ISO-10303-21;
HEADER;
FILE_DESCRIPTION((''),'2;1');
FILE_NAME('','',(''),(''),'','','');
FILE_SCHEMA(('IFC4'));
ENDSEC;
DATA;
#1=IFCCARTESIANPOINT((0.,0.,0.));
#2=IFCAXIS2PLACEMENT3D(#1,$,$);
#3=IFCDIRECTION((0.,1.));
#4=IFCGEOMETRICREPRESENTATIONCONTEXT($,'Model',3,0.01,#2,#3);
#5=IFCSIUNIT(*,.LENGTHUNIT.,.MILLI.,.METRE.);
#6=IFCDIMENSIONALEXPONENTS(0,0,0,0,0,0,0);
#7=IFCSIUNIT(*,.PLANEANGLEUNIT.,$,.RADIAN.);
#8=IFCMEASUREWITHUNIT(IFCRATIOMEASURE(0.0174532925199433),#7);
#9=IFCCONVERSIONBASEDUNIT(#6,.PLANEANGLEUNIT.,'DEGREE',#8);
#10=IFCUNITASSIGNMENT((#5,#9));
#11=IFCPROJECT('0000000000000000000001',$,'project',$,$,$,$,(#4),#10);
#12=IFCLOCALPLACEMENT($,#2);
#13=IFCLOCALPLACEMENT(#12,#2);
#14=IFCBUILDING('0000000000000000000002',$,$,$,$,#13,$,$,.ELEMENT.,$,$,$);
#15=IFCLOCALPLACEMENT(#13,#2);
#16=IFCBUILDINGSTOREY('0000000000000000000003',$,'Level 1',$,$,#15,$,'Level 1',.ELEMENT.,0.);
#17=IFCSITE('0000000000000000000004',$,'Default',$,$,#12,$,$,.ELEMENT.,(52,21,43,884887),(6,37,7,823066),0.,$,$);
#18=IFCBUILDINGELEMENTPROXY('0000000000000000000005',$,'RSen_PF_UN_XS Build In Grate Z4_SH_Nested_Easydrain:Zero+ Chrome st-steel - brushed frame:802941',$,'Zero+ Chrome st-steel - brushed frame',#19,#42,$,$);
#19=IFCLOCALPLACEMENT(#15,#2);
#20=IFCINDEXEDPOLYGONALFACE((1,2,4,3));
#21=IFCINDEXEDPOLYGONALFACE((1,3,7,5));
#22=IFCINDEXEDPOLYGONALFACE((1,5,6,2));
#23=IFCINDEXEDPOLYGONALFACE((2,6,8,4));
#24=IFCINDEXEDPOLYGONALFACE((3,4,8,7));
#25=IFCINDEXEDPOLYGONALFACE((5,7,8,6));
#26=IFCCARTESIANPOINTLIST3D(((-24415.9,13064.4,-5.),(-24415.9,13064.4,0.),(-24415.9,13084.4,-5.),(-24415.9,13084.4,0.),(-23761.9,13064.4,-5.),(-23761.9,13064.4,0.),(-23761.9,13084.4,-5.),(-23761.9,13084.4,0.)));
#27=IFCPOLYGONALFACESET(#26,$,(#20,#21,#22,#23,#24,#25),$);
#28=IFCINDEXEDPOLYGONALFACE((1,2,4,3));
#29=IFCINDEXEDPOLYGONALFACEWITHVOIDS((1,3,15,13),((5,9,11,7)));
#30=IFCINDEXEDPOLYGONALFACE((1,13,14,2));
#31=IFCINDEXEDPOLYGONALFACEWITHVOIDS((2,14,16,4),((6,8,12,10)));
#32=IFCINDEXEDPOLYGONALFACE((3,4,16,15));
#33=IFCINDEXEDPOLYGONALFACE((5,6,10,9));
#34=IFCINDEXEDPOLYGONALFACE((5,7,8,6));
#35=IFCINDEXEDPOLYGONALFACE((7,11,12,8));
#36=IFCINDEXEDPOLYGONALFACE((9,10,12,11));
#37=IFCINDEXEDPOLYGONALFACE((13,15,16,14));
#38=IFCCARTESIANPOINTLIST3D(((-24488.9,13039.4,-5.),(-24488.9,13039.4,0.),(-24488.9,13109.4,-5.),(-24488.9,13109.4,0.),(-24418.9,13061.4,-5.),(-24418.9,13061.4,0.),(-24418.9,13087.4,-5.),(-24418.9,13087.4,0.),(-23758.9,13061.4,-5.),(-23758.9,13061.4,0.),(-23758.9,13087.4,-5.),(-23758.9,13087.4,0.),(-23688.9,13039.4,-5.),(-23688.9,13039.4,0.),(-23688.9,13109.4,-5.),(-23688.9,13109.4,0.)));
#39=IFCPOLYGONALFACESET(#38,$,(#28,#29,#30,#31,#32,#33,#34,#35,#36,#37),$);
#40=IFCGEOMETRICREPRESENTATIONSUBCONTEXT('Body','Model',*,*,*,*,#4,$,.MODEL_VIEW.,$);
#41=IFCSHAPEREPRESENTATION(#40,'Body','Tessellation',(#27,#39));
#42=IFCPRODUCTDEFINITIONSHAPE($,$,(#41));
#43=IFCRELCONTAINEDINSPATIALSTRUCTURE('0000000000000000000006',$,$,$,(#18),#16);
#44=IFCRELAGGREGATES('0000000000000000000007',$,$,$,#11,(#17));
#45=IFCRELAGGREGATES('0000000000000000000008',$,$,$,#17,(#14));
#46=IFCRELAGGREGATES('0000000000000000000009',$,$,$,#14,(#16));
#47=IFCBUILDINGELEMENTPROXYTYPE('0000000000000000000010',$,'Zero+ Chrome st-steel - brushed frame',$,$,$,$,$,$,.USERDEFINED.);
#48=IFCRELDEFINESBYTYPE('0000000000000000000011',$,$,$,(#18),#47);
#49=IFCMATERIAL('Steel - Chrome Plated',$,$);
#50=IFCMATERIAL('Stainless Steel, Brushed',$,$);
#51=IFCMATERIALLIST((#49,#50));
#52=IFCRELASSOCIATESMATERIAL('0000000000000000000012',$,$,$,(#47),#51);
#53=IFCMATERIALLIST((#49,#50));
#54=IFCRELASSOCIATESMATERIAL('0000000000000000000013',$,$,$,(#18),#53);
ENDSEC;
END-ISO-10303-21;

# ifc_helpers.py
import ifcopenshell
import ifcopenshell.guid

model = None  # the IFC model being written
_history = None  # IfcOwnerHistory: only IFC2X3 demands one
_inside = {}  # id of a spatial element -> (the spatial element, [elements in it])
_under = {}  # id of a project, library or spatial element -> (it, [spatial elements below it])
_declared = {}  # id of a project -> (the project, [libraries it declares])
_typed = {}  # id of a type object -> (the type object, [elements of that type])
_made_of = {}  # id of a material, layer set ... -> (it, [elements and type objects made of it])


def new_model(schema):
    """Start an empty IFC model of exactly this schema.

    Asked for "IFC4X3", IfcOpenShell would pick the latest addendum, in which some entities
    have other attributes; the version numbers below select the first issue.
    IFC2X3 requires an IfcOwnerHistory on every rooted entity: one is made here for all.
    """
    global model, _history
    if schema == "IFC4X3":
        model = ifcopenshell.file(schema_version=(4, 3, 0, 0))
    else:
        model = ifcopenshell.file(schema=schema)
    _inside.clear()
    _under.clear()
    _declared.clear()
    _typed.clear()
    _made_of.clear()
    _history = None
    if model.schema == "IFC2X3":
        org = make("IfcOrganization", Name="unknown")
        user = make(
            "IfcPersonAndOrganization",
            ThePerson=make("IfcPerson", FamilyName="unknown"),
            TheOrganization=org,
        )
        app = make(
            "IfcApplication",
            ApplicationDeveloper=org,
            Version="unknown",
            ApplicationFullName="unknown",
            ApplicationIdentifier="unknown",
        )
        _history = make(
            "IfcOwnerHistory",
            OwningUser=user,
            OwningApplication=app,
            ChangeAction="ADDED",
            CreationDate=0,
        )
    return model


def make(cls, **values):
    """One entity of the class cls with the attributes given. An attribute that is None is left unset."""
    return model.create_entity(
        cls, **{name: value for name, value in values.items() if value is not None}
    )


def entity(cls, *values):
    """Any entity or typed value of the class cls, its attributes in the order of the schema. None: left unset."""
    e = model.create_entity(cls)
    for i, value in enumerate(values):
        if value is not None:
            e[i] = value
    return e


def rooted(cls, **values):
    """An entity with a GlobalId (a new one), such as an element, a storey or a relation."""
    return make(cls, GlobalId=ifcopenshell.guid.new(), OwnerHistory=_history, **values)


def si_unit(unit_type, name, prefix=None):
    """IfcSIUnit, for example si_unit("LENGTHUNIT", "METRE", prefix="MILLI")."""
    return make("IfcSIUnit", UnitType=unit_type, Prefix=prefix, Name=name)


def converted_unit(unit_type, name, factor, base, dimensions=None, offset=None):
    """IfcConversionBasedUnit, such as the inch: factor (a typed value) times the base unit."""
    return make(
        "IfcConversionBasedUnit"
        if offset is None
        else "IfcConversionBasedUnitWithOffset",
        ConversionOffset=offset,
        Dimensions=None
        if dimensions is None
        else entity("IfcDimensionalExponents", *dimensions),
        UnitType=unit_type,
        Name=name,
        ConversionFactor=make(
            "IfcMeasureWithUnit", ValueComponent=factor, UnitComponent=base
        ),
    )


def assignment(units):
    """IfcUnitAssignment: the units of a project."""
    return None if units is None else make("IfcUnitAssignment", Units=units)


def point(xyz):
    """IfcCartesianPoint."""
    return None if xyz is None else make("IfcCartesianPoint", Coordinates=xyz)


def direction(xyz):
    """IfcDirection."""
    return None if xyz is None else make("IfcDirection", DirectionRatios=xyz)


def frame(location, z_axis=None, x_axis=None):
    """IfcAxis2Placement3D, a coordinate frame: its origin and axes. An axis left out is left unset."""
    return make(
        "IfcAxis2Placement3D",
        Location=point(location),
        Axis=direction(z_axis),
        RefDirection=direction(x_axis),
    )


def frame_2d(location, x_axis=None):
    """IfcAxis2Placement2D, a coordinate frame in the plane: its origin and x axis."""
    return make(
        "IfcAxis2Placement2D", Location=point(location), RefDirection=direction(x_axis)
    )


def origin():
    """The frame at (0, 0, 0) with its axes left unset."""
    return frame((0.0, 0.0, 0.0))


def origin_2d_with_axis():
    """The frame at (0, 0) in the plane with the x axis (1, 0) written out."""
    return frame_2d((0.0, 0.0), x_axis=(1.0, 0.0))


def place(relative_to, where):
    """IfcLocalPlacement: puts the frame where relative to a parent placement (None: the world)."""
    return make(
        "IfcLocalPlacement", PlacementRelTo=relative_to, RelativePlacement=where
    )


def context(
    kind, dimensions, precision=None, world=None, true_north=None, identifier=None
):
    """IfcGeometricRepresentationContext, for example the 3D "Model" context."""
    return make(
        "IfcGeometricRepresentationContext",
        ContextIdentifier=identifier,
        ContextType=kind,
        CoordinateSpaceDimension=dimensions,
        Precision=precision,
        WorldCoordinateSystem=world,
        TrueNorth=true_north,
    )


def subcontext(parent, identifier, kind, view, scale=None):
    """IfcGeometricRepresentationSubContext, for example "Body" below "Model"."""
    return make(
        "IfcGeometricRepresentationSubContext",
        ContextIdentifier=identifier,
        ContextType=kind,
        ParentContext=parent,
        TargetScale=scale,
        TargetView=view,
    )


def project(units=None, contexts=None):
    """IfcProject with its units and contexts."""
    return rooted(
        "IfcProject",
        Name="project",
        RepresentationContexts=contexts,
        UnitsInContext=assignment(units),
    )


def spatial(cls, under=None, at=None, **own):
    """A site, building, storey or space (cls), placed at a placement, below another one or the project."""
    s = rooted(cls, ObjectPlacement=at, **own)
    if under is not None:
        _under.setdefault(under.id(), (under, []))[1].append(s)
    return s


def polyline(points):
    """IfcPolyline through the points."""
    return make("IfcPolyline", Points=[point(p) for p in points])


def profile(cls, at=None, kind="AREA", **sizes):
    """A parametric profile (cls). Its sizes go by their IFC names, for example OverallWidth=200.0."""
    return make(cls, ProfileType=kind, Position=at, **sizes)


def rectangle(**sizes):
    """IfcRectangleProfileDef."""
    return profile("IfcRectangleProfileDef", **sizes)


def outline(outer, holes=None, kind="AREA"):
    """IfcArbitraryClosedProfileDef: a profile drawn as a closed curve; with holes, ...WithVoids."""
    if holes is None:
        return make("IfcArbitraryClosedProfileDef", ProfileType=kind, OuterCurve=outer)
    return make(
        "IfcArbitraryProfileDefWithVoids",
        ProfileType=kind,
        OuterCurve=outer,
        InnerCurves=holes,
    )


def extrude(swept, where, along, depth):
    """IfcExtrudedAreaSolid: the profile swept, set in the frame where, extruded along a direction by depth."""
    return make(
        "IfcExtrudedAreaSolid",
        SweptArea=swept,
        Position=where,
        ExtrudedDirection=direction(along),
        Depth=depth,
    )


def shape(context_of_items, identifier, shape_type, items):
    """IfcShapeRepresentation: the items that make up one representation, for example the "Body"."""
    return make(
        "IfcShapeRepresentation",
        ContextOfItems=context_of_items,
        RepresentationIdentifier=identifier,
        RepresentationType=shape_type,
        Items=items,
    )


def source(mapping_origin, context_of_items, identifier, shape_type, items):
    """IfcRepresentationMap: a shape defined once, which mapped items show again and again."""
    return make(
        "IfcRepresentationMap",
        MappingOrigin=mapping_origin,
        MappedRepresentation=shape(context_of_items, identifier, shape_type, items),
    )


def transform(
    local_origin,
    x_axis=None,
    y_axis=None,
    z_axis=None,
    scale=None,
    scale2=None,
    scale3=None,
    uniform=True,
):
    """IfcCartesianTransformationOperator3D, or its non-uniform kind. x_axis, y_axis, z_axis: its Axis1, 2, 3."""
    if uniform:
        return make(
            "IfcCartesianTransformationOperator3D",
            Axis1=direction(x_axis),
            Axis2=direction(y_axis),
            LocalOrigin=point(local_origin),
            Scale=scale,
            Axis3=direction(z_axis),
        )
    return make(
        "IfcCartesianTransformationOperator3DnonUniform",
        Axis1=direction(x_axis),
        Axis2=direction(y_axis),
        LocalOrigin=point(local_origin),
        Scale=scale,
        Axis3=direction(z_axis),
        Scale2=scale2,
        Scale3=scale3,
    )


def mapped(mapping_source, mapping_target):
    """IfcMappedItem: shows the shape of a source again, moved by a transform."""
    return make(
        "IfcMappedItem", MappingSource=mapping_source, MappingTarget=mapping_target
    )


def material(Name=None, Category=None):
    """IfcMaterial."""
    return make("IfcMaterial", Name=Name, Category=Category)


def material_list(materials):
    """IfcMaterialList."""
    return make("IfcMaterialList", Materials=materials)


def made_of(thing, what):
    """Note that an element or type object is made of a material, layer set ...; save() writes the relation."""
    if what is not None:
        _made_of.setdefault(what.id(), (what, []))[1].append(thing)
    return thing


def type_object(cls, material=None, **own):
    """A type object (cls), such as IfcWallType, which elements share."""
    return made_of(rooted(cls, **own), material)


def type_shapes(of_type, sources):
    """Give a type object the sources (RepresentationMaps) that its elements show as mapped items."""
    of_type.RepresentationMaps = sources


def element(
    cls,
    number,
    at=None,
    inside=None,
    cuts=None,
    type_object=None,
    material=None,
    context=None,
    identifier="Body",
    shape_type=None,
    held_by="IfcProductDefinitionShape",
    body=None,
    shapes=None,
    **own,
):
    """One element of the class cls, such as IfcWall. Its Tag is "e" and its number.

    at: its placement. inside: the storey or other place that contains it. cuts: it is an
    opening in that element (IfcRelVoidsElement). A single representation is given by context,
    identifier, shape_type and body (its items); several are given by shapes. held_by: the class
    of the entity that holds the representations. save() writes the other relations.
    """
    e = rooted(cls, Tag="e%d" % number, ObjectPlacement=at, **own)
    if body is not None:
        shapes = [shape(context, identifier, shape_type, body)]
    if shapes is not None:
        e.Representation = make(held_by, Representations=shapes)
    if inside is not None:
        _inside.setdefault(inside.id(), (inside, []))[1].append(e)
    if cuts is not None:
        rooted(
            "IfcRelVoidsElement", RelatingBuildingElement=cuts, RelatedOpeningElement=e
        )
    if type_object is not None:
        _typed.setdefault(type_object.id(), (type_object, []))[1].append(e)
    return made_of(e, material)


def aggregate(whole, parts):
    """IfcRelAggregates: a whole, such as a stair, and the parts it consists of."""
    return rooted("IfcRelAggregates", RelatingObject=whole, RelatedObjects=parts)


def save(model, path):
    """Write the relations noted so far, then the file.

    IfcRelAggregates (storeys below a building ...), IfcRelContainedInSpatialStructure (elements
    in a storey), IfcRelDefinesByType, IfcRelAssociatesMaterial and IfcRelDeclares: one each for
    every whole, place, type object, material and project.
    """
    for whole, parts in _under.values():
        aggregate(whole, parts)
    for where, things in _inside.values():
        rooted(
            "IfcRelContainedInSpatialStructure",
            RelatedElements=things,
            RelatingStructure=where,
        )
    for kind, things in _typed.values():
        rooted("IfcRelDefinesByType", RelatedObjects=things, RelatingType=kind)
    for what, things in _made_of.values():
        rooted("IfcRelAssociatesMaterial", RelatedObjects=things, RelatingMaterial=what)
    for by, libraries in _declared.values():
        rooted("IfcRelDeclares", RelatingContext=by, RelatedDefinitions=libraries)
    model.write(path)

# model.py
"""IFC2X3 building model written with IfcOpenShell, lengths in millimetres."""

from ifc_helpers import new_model, entity, si_unit, converted_unit, direction, frame, origin, origin_2d_with_axis, place, context, subcontext, project, spatial, polyline, rectangle, outline, extrude, source, transform, mapped, material, material_list, type_object, type_shapes, element, save


model = new_model("IFC2X3")

# Units and contexts
model_context = context("Model", 3, precision=0.01, world=origin(), true_north=direction((0.0, 1.0)))
body_context = subcontext(model_context, "Body", "Model", "MODEL_VIEW")
ifc_project = project(units=[si_unit("LENGTHUNIT", "METRE", prefix="MILLI"), converted_unit("PLANEANGLEUNIT", "DEGREE", entity("IfcRatioMeasure", 0.0174532925199433), si_unit("PLANEANGLEUNIT", "RADIAN"), dimensions=[0, 0, 0, 0, 0, 0, 0])], contexts=[model_context])

# Site, building, storey
site_placement = place(None, origin())
site = spatial("IfcSite", under=ifc_project, at=site_placement, Name="Default", CompositionType="ELEMENT", RefLatitude=(52, 21, 43, 884887), RefLongitude=(6, 37, 7, 823066), RefElevation=0.0)
building_placement = place(site_placement, origin())
building = spatial("IfcBuilding", under=site, at=building_placement, CompositionType="ELEMENT")
storey_placement = place(building_placement, origin())
storey = spatial("IfcBuildingStorey", under=building, at=storey_placement, Name="Level 1", LongName="Level 1", CompositionType="ELEMENT", Elevation=0.0)

# Shared definitions
ifc_material_1 = material(Name="Stainless Steel, Brushed")

# Building element proxy
ifc_material_2 = material(Name="Steel - Chrome Plated")
ifc_material_list_1 = material_list([ifc_material_2, ifc_material_1])
ifc_material_list_2 = material_list([ifc_material_2, ifc_material_1])
building_element_proxy_type_1 = type_object("IfcBuildingElementProxyType", Name="Zero+ Chrome st-steel - brushed frame", PredefinedType="USERDEFINED", material=ifc_material_list_2)
shared_shape_1 = source(origin(), body_context, "Body", "SweptSolid", [
    extrude(rectangle(XDim=654.0, YDim=20.0, at=origin_2d_with_axis()), frame((0.0, 0.0, 0.0), z_axis=(0.0, 0.0, 1.0), x_axis=(-1.0, 0.0, 0.0)), (0.0, 0.0, 1.0), 5.0),
    extrude(outline(polyline([(-400.0, -35.0), (400.0, -35.0), (400.0, 35.0), (-400.0, 35.0), (-400.0, -35.0)]), holes=[polyline([(-330.0, -13.0), (-330.0, 13.0), (330.0, 13.0), (330.0, -13.0), (-330.0, -13.0)])]), frame((0.0, 0.0, 0.0), z_axis=(0.0, 0.0, 1.0), x_axis=(-1.0, 0.0, 0.0)), (0.0, 0.0, 1.0), 5.0),
])
type_shapes(building_element_proxy_type_1, [shared_shape_1])
proxy_1_placement = place(storey_placement, frame((-24088.9, 13074.4, -5.0)))
element("IfcBuildingElementProxy", 1, at=proxy_1_placement, inside=storey, type_object=building_element_proxy_type_1, material=ifc_material_list_1, Name="RSen_PF_UN_XS Build In Grate Z4_SH_Nested_Easydrain:Zero+ Chrome st-steel - brushed frame:802941", ObjectType="Zero+ Chrome st-steel - brushed frame", context=body_context, shape_type="MappedRepresentation", body=[
    mapped(shared_shape_1, transform((0.0, 0.0, 0.0), scale=1.0)),
])

save(model, "model.ifc")
